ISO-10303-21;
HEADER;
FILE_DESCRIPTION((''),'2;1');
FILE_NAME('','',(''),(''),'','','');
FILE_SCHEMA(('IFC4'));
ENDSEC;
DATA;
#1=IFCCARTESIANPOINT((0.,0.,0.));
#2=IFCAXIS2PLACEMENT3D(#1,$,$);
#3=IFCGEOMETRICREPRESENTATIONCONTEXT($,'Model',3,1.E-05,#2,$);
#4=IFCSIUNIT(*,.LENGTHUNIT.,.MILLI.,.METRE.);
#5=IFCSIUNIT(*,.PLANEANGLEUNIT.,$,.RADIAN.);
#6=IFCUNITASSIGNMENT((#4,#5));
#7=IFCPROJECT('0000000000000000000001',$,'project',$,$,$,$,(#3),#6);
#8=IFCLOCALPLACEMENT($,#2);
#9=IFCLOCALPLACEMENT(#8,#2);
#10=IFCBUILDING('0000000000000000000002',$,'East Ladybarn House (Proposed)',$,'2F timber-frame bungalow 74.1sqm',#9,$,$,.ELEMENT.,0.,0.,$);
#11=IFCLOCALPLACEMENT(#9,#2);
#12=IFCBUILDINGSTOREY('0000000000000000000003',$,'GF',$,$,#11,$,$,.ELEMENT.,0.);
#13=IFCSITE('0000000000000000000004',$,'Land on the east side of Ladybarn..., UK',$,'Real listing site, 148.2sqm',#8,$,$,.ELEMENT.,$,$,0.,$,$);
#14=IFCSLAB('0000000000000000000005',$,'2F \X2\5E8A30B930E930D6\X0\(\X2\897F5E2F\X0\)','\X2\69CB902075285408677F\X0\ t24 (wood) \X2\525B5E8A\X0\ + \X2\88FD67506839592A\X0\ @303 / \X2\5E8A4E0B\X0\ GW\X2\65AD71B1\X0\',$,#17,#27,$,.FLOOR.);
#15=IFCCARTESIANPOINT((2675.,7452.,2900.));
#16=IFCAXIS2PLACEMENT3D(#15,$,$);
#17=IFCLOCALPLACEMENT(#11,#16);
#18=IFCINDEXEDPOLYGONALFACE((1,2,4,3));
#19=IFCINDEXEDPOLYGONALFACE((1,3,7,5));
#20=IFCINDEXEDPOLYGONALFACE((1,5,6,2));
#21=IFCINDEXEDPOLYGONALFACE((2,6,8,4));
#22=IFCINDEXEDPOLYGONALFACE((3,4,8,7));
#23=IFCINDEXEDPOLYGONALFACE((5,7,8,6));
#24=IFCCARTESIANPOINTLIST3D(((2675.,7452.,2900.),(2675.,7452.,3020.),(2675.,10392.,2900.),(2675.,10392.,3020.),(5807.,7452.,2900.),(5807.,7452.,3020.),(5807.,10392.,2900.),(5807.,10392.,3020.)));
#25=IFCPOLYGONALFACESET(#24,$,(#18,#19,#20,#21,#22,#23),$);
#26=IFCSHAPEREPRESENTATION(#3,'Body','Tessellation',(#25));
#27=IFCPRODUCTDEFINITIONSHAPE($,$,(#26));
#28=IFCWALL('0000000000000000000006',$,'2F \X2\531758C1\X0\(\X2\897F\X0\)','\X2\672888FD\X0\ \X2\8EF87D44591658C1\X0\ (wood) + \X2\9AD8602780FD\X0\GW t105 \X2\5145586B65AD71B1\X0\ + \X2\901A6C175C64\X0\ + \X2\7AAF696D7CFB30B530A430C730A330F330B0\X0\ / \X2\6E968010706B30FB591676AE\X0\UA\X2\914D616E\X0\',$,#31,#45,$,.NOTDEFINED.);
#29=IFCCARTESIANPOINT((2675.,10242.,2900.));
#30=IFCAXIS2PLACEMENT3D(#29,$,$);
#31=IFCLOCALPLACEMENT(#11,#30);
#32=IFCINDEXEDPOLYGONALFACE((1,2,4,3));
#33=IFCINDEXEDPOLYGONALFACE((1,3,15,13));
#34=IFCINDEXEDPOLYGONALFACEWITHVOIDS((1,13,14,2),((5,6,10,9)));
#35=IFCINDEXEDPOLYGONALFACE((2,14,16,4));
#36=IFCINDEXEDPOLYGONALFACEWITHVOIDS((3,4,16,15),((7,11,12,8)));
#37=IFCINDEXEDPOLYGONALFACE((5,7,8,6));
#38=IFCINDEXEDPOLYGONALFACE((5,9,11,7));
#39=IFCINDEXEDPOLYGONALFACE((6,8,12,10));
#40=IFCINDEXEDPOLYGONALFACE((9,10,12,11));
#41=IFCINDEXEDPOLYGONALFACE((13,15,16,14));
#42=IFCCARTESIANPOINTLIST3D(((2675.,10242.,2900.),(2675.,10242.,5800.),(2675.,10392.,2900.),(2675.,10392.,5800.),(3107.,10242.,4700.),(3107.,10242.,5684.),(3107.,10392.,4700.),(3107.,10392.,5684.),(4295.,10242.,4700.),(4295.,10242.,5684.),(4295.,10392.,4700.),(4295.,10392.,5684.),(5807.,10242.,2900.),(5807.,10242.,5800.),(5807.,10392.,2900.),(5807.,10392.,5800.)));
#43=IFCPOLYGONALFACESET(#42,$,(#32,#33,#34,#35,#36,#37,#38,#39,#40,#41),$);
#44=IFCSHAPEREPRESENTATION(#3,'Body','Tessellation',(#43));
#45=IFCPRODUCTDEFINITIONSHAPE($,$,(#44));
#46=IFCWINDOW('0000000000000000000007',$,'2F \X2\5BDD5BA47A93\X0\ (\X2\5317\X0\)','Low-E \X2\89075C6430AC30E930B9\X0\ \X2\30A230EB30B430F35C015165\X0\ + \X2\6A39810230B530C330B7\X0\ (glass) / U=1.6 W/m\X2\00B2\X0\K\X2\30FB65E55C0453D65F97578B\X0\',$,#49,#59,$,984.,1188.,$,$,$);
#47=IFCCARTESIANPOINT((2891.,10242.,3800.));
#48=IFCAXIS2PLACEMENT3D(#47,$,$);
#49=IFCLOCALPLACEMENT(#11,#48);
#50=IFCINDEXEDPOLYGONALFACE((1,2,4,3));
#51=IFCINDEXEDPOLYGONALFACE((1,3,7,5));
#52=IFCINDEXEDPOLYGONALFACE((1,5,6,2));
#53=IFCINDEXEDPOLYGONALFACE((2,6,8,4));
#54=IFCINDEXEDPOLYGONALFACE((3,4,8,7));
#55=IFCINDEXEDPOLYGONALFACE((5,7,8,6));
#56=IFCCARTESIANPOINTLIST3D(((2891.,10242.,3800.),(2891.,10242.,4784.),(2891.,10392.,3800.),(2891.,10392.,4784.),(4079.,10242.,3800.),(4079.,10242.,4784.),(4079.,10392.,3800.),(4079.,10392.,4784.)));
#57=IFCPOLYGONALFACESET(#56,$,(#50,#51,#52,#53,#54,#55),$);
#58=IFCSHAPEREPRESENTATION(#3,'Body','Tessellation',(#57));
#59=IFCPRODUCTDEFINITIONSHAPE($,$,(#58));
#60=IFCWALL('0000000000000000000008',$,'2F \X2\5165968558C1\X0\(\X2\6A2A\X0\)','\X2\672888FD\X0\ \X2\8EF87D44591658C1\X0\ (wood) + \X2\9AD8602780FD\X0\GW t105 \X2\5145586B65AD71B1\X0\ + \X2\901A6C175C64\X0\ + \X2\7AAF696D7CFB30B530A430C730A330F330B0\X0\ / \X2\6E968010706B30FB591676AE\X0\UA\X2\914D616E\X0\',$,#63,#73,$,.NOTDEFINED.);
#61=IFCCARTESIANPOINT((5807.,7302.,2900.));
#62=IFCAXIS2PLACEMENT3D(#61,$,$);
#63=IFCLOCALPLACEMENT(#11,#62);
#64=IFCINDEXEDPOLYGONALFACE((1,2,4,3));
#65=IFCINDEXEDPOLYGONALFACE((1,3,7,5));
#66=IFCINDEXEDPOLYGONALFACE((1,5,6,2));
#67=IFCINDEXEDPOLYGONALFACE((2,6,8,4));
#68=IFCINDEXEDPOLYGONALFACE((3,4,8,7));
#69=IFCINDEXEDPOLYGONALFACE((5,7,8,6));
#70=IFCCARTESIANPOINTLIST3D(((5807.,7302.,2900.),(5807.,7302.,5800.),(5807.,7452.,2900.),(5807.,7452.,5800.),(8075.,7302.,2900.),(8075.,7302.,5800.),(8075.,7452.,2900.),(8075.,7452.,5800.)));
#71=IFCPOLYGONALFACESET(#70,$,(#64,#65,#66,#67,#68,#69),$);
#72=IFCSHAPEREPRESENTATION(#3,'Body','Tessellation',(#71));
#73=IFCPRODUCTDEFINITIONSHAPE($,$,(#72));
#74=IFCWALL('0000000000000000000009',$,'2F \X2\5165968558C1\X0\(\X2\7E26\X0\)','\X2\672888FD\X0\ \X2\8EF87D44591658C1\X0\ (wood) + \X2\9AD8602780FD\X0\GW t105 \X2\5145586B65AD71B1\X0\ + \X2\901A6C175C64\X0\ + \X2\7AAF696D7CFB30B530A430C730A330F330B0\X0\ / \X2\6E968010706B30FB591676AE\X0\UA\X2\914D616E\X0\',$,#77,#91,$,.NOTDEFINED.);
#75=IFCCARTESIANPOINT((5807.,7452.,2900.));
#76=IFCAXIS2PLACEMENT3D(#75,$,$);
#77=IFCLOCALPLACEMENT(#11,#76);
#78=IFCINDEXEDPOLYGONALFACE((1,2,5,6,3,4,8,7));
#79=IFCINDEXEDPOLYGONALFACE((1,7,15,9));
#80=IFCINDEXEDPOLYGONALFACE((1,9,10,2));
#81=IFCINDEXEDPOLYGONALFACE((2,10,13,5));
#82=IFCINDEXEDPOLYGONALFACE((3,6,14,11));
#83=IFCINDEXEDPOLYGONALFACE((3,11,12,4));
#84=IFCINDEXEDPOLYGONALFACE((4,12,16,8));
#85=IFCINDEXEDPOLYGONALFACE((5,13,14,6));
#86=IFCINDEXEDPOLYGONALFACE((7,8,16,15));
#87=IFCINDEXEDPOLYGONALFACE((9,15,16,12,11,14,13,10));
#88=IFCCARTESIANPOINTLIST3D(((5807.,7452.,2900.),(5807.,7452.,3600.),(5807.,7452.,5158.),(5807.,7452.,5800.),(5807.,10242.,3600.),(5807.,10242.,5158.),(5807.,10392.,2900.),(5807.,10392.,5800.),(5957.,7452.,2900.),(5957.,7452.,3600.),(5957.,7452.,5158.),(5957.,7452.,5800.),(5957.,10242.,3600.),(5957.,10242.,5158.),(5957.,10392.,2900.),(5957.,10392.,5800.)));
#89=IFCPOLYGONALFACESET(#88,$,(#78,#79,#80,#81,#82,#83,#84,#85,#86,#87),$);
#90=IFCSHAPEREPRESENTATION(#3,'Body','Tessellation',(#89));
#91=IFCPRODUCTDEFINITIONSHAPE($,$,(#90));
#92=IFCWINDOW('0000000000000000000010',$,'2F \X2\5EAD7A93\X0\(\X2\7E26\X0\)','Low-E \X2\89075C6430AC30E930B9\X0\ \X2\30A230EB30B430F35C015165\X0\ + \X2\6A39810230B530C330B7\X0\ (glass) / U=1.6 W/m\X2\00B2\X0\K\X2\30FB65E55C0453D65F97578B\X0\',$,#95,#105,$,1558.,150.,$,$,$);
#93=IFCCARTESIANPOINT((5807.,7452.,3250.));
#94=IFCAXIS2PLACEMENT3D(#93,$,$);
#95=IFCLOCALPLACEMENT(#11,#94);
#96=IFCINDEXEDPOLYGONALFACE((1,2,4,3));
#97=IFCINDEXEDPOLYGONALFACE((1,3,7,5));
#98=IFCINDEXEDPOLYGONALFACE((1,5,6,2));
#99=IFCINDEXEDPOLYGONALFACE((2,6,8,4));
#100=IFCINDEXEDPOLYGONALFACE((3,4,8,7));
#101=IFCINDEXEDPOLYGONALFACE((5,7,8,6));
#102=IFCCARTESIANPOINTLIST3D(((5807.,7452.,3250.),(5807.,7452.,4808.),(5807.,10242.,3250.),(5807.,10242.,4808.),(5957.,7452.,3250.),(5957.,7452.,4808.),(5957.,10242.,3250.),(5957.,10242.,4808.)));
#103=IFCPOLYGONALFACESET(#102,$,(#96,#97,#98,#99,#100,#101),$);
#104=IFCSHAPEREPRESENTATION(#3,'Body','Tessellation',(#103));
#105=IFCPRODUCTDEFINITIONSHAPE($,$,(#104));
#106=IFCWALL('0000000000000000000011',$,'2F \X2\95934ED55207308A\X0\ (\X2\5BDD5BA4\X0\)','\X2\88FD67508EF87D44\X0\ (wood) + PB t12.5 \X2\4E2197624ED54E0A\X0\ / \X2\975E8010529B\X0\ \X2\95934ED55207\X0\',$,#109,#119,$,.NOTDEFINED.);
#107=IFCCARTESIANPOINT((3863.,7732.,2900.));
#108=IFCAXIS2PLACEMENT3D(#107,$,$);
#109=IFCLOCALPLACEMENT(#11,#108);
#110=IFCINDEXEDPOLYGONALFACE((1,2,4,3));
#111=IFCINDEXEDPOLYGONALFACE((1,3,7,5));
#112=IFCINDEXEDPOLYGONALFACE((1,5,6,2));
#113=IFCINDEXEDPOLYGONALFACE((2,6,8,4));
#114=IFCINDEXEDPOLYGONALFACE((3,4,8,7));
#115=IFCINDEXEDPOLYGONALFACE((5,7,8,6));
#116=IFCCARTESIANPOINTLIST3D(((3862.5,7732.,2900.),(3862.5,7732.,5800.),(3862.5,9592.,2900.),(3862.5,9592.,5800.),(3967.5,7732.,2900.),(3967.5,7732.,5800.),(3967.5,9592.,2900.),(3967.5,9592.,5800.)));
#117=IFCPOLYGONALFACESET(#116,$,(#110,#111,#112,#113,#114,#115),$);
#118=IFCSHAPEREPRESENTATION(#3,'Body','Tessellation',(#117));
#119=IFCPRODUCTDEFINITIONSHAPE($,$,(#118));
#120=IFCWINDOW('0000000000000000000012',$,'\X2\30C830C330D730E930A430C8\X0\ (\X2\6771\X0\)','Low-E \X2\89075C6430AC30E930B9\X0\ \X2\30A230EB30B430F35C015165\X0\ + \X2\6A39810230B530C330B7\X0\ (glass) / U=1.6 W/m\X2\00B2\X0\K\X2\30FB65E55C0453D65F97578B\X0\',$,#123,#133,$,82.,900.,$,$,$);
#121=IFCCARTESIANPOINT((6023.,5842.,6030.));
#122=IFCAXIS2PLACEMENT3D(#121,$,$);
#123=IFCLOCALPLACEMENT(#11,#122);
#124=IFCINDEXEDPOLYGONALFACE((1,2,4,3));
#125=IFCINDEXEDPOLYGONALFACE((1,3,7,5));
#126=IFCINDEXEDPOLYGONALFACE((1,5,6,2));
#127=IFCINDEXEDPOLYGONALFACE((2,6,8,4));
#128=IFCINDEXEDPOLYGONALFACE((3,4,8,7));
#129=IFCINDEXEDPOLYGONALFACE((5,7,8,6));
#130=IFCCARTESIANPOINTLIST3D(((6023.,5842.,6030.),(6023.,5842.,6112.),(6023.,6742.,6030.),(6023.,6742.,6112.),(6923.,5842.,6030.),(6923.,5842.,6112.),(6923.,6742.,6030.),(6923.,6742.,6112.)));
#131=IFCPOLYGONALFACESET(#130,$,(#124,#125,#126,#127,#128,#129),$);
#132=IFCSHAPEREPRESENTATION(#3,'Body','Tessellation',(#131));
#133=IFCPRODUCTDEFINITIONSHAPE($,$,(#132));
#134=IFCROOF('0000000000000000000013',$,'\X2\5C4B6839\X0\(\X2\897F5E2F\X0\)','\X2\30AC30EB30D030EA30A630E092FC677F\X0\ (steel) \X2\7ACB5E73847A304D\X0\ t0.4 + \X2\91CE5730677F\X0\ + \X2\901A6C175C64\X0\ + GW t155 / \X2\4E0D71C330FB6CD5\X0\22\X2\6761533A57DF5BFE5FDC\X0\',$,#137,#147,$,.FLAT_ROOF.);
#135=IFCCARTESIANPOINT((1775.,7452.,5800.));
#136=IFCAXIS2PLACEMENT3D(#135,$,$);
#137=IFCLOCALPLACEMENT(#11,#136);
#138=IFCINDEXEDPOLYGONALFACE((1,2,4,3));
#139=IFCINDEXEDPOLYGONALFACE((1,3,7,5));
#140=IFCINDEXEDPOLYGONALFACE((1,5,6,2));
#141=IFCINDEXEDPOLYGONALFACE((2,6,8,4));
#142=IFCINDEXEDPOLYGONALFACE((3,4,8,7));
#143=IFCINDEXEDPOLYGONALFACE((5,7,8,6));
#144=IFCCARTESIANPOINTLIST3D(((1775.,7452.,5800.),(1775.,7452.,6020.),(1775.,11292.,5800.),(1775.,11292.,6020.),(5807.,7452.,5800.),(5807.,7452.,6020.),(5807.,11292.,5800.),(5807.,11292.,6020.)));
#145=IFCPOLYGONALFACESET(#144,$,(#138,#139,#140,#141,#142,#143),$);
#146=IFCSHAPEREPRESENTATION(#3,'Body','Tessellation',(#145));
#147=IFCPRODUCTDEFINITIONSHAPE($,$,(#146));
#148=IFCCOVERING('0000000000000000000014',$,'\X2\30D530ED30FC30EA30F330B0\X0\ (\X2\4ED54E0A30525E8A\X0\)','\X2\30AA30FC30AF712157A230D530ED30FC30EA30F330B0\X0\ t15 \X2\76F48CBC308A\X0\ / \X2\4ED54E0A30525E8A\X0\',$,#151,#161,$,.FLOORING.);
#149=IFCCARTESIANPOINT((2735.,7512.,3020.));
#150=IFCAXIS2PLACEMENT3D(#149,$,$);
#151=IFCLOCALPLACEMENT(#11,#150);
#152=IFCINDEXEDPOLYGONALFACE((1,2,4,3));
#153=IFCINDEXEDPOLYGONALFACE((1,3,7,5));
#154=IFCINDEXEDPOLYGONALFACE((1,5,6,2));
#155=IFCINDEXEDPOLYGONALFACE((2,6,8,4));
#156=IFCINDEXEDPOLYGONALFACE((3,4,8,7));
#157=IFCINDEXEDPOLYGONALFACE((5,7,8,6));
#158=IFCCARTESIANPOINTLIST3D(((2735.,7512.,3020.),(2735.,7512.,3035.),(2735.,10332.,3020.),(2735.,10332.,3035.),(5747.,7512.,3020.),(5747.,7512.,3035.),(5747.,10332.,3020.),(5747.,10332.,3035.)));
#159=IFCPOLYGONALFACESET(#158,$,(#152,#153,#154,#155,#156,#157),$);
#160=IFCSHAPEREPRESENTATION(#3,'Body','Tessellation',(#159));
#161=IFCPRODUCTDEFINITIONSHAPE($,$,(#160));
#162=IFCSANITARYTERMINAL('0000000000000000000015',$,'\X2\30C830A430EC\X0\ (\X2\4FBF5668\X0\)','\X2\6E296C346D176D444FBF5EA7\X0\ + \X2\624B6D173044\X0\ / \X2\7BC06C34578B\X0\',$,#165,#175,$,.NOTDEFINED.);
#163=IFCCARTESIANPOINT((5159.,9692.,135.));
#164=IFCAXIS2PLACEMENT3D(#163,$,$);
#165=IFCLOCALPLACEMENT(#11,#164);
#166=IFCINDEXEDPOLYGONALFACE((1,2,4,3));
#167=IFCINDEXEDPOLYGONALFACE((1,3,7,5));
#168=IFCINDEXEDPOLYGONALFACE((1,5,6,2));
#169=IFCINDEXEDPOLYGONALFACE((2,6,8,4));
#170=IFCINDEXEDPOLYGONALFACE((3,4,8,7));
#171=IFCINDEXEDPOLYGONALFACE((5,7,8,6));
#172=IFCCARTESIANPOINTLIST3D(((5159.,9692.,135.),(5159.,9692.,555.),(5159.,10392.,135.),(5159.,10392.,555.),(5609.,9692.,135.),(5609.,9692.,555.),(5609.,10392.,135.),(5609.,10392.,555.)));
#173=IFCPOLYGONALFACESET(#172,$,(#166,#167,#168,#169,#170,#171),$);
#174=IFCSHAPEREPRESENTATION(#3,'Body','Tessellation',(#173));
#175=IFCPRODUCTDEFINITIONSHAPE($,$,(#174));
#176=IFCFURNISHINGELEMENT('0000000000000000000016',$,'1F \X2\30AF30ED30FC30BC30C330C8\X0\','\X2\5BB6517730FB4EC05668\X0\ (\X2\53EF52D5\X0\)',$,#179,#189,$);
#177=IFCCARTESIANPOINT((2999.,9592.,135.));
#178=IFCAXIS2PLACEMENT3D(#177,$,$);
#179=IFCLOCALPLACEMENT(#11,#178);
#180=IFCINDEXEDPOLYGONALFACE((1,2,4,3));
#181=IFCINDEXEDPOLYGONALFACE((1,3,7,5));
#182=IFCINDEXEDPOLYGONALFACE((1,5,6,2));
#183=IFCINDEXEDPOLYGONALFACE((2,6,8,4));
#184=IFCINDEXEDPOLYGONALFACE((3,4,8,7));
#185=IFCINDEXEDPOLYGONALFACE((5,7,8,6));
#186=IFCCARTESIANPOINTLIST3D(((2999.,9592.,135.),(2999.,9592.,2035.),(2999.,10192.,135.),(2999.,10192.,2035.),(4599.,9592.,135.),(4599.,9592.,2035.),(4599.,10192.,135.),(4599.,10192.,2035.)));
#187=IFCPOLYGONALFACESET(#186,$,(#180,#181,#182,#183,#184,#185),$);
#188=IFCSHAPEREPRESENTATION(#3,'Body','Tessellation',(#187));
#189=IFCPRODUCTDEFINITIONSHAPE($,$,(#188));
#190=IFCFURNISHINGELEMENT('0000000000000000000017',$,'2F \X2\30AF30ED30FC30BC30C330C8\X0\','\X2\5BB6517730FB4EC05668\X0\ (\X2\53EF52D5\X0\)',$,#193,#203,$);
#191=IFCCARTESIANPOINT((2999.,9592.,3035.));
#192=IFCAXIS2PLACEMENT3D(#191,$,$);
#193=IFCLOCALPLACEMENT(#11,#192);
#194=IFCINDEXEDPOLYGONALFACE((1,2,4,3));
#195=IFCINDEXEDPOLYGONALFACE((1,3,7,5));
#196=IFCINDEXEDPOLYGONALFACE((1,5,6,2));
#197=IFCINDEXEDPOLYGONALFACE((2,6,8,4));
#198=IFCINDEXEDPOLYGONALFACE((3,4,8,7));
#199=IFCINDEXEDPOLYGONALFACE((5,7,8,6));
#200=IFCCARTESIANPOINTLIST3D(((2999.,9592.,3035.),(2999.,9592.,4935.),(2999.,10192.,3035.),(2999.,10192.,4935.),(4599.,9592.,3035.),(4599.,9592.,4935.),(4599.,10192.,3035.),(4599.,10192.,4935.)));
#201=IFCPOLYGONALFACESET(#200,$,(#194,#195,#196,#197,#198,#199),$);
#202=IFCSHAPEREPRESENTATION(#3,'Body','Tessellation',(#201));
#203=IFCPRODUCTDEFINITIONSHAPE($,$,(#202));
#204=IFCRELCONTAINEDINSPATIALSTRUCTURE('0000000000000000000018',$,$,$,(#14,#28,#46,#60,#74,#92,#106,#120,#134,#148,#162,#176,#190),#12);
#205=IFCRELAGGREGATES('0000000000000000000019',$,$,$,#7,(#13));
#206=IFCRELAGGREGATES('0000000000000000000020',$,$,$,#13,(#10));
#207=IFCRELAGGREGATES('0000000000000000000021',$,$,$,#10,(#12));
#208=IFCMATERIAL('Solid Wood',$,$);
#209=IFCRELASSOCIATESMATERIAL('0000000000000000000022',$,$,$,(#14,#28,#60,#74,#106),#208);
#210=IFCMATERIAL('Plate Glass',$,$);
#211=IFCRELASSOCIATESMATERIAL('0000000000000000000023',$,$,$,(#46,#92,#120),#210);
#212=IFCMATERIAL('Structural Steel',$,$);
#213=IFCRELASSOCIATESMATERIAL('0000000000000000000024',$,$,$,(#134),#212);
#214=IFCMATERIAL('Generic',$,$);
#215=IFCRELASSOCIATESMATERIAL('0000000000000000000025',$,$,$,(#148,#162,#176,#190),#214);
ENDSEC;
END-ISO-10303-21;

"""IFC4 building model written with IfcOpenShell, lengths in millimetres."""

from ifc_helpers import new_model, si_unit, frame, frame_2d, origin, place, context, project, spatial, rectangle, extrude, material, element, fill, save


model = new_model("IFC4")

# Units and contexts
model_context = context("Model", 3, precision=1e-05, world=origin())
ifc_project = project(units=[si_unit("LENGTHUNIT", "METRE", prefix="MILLI"), si_unit("PLANEANGLEUNIT", "RADIAN")], contexts=[model_context])

# Site, building, storey
site_placement = place(None, origin())
site = spatial("IfcSite", under=ifc_project, at=site_placement, Name="Land on the east side of Ladybarn..., UK", ObjectType="Real listing site, 148.2sqm", CompositionType="ELEMENT", RefElevation=0.0)
building_placement = place(site_placement, origin())
building = spatial("IfcBuilding", under=site, at=building_placement, Name="East Ladybarn House (Proposed)", ObjectType="2F timber-frame bungalow 74.1sqm", CompositionType="ELEMENT", ElevationOfRefHeight=0.0, ElevationOfTerrain=0.0)
storey_placement = place(building_placement, origin())
storey = spatial("IfcBuildingStorey", under=building, at=storey_placement, Name="GF", CompositionType="ELEMENT", Elevation=0.0)

# Slab
ifc_material_1 = material(Name="Solid Wood")
slab_placement = place(storey_placement, frame((2675.0, 7452.0, 2900.0)))
element("IfcSlab", 1, at=slab_placement, inside=storey, material=ifc_material_1, Name="2F 床スラブ(西帯)", Description="構造用合板 t24 (wood) 剛床 + 製材根太 @303 / 床下 GW断熱", PredefinedType="FLOOR", context=model_context, shape_type="SweptSolid", body=[
    extrude(rectangle(XDim=3132.0, YDim=2940.0, at=frame_2d((1566.0, 1470.0))), frame((2675.0, 7452.0, 2900.0)), (0.0, 0.0, 1.0), 120.0),
])

# Wall, opening, window
wall_1_placement = place(storey_placement, frame((2675.0, 10242.0, 2900.0)))
wall_1 = element("IfcWall", 2, at=wall_1_placement, inside=storey, material=ifc_material_1, Name="2F 北壁(西)", Description="木製 軸組外壁 (wood) + 高性能GW t105 充填断熱 + 通気層 + 窯業系サイディング / 準耐火・外皮UA配慮", PredefinedType="NOTDEFINED", context=model_context, shape_type="SweptSolid", body=[
    extrude(rectangle(XDim=3132.0, YDim=150.0, at=frame_2d((1566.0, 75.0))), frame((2675.0, 10242.0, 2900.0)), (0.0, 0.0, 1.0), 2900.0),
])
opening_1_placement = place(storey_placement, frame((2891.0, 10242.0, 3800.0)))
opening_1 = element("IfcOpeningElement", 3, at=opening_1_placement, cuts=wall_1, PredefinedType="NOTDEFINED", context=model_context, shape_type="SweptSolid", body=[
    extrude(rectangle(XDim=1188.0, YDim=150.0, at=frame_2d((594.0, 75.0))), frame((2891.0, 10242.0, 3800.0)), (0.0, 0.0, 1.0), 984.0),
])
ifc_material_2 = material(Name="Plate Glass")
window_1_placement = place(storey_placement, frame((2891.0, 10242.0, 3800.0)))
window_1 = element("IfcWindow", 4, at=window_1_placement, inside=storey, material=ifc_material_2, Name="2F 寝室窓 (北)", Description="Low-E 複層ガラス アルゴン封入 + 樹脂サッシ (glass) / U=1.6 W/m²K・日射取得型", OverallHeight=984.0, OverallWidth=1188.0, context=model_context, shape_type="SweptSolid", body=[
    extrude(rectangle(XDim=1188.0, YDim=150.0, at=frame_2d((594.0, 75.0))), frame((2891.0, 10242.0, 3800.0)), (0.0, 0.0, 1.0), 984.0),
])
fill(opening_1, window_1)

# Wall
wall_2_placement = place(storey_placement, frame((5807.0, 7302.0, 2900.0)))
element("IfcWall", 5, at=wall_2_placement, inside=storey, material=ifc_material_1, Name="2F 入隅壁(横)", Description="木製 軸組外壁 (wood) + 高性能GW t105 充填断熱 + 通気層 + 窯業系サイディング / 準耐火・外皮UA配慮", PredefinedType="NOTDEFINED", context=model_context, shape_type="SweptSolid", body=[
    extrude(rectangle(XDim=2268.0, YDim=150.0, at=frame_2d((1134.0, 75.0))), frame((5807.0, 7302.0, 2900.0)), (0.0, 0.0, 1.0), 2900.0),
])

# Wall, opening, window
wall_3_placement = place(storey_placement, frame((5807.0, 7452.0, 2900.0)))
wall_3 = element("IfcWall", 6, at=wall_3_placement, inside=storey, material=ifc_material_1, Name="2F 入隅壁(縦)", Description="木製 軸組外壁 (wood) + 高性能GW t105 充填断熱 + 通気層 + 窯業系サイディング / 準耐火・外皮UA配慮", PredefinedType="NOTDEFINED", context=model_context, shape_type="SweptSolid", body=[
    extrude(rectangle(XDim=150.0, YDim=2940.0, at=frame_2d((75.0, 1470.0))), frame((5807.0, 7452.0, 2900.0)), (0.0, 0.0, 1.0), 2900.0),
])
opening_2_placement = place(storey_placement, frame((5807.0, 7452.0, 3250.0)))
opening_2 = element("IfcOpeningElement", 7, at=opening_2_placement, cuts=wall_3, PredefinedType="NOTDEFINED", context=model_context, shape_type="SweptSolid", body=[
    extrude(rectangle(XDim=150.0, YDim=2790.0, at=frame_2d((75.0, 1395.0))), frame((5807.0, 7452.0, 3250.0)), (0.0, 0.0, 1.0), 1558.0),
])
window_2_placement = place(storey_placement, frame((5807.0, 7452.0, 3250.0)))
window_2 = element("IfcWindow", 8, at=window_2_placement, inside=storey, material=ifc_material_2, Name="2F 庭窓(縦)", Description="Low-E 複層ガラス アルゴン封入 + 樹脂サッシ (glass) / U=1.6 W/m²K・日射取得型", OverallHeight=1558.0, OverallWidth=150.0, context=model_context, shape_type="SweptSolid", body=[
    extrude(rectangle(XDim=150.0, YDim=2790.0, at=frame_2d((75.0, 1395.0))), frame((5807.0, 7452.0, 3250.0)), (0.0, 0.0, 1.0), 1558.0),
])
fill(opening_2, window_2)

# Wall
wall_4_placement = place(storey_placement, frame((3863.0, 7732.0, 2900.0)))
element("IfcWall", 9, at=wall_4_placement, inside=storey, material=ifc_material_1, Name="2F 間仕切り (寝室)", Description="製材軸組 (wood) + PB t12.5 両面仕上 / 非耐力 間仕切", PredefinedType="NOTDEFINED", context=model_context, shape_type="SweptSolid", body=[
    extrude(rectangle(XDim=105.0, YDim=1860.0, at=frame_2d((52.0, 930.0))), frame((3863.0, 7732.0, 2900.0)), (0.0, 0.0, 1.0), 2900.0),
])

# Window
window_3_placement = place(storey_placement, frame((6023.0, 5842.0, 6030.0)))
element("IfcWindow", 10, at=window_3_placement, inside=storey, material=ifc_material_2, Name="トップライト (東)", Description="Low-E 複層ガラス アルゴン封入 + 樹脂サッシ (glass) / U=1.6 W/m²K・日射取得型", OverallHeight=82.0, OverallWidth=900.0, context=model_context, shape_type="SweptSolid", body=[
    extrude(rectangle(XDim=900.0, YDim=900.0, at=frame_2d((450.0, 450.0))), frame((6023.0, 5842.0, 6030.0)), (0.0, 0.0, 1.0), 82.0),
])

# Roof
ifc_material_3 = material(Name="Structural Steel")
for number, where, name in (
    (11, (1775.0, 7452.0, 5800.0), "屋根(西帯)"),
):
    element("IfcRoof", number, at=place(storey_placement, frame(where)), inside=storey, material=ifc_material_3, Name=name, Description="ガルバリウム鋼板 (steel) 立平葺き t0.4 + 野地板 + 通気層 + GW t155 / 不燃・法22条区域対応", PredefinedType="FLAT_ROOF", context=model_context, shape_type="SweptSolid", body=[
        extrude(rectangle(XDim=4032.0, YDim=3840.0, at=frame_2d((2016.0, 1920.0))), frame((1775.0, 7452.0, 5800.0)), (0.0, 0.0, 1.0), 220.0),
    ])

# Covering
ifc_material_4 = material(Name="Generic")
covering_placement = place(storey_placement, frame((2735.0, 7512.0, 3020.0)))
element("IfcCovering", 12, at=covering_placement, inside=storey, material=ifc_material_4, Name="フローリング (仕上げ床)", Description="オーク無垢フローリング t15 直貼り / 仕上げ床", PredefinedType="FLOORING", context=model_context, shape_type="SweptSolid", body=[
    extrude(rectangle(XDim=3012.0, YDim=2820.0, at=frame_2d((1506.0, 1410.0))), frame((2735.0, 7512.0, 3020.0)), (0.0, 0.0, 1.0), 15.0),
])

# Sanitary terminal
sanitary_terminal_placement = place(storey_placement, frame((5159.0, 9692.0, 135.0)))
element("IfcSanitaryTerminal", 13, at=sanitary_terminal_placement, inside=storey, material=ifc_material_4, Name="トイレ (便器)", Description="温水洗浄便座 + 手洗い / 節水型", PredefinedType="NOTDEFINED", context=model_context, shape_type="SweptSolid", body=[
    extrude(rectangle(XDim=450.0, YDim=700.0, at=frame_2d((225.0, 350.0))), frame((5159.0, 9692.0, 135.0)), (0.0, 0.0, 1.0), 420.0),
])

# Furnishing elements
furnishing_1_placement = place(storey_placement, frame((2999.0, 9592.0, 135.0)))
element("IfcFurnishingElement", 14, at=furnishing_1_placement, inside=storey, material=ifc_material_4, Name="1F クローゼット", Description="家具・什器 (可動)", context=model_context, shape_type="SweptSolid", body=[
    extrude(rectangle(XDim=1600.0, YDim=600.0, at=frame_2d((800.0, 300.0))), frame((2999.0, 9592.0, 135.0)), (0.0, 0.0, 1.0), 1900.0),
])
furnishing_2_placement = place(storey_placement, frame((2999.0, 9592.0, 3035.0)))
element("IfcFurnishingElement", 15, at=furnishing_2_placement, inside=storey, material=ifc_material_4, Name="2F クローゼット", Description="家具・什器 (可動)", context=model_context, shape_type="SweptSolid", body=[
    extrude(rectangle(XDim=1600.0, YDim=600.0, at=frame_2d((800.0, 300.0))), frame((2999.0, 9592.0, 3035.0)), (0.0, 0.0, 1.0), 1900.0),
])

save(model, "model.ifc")
